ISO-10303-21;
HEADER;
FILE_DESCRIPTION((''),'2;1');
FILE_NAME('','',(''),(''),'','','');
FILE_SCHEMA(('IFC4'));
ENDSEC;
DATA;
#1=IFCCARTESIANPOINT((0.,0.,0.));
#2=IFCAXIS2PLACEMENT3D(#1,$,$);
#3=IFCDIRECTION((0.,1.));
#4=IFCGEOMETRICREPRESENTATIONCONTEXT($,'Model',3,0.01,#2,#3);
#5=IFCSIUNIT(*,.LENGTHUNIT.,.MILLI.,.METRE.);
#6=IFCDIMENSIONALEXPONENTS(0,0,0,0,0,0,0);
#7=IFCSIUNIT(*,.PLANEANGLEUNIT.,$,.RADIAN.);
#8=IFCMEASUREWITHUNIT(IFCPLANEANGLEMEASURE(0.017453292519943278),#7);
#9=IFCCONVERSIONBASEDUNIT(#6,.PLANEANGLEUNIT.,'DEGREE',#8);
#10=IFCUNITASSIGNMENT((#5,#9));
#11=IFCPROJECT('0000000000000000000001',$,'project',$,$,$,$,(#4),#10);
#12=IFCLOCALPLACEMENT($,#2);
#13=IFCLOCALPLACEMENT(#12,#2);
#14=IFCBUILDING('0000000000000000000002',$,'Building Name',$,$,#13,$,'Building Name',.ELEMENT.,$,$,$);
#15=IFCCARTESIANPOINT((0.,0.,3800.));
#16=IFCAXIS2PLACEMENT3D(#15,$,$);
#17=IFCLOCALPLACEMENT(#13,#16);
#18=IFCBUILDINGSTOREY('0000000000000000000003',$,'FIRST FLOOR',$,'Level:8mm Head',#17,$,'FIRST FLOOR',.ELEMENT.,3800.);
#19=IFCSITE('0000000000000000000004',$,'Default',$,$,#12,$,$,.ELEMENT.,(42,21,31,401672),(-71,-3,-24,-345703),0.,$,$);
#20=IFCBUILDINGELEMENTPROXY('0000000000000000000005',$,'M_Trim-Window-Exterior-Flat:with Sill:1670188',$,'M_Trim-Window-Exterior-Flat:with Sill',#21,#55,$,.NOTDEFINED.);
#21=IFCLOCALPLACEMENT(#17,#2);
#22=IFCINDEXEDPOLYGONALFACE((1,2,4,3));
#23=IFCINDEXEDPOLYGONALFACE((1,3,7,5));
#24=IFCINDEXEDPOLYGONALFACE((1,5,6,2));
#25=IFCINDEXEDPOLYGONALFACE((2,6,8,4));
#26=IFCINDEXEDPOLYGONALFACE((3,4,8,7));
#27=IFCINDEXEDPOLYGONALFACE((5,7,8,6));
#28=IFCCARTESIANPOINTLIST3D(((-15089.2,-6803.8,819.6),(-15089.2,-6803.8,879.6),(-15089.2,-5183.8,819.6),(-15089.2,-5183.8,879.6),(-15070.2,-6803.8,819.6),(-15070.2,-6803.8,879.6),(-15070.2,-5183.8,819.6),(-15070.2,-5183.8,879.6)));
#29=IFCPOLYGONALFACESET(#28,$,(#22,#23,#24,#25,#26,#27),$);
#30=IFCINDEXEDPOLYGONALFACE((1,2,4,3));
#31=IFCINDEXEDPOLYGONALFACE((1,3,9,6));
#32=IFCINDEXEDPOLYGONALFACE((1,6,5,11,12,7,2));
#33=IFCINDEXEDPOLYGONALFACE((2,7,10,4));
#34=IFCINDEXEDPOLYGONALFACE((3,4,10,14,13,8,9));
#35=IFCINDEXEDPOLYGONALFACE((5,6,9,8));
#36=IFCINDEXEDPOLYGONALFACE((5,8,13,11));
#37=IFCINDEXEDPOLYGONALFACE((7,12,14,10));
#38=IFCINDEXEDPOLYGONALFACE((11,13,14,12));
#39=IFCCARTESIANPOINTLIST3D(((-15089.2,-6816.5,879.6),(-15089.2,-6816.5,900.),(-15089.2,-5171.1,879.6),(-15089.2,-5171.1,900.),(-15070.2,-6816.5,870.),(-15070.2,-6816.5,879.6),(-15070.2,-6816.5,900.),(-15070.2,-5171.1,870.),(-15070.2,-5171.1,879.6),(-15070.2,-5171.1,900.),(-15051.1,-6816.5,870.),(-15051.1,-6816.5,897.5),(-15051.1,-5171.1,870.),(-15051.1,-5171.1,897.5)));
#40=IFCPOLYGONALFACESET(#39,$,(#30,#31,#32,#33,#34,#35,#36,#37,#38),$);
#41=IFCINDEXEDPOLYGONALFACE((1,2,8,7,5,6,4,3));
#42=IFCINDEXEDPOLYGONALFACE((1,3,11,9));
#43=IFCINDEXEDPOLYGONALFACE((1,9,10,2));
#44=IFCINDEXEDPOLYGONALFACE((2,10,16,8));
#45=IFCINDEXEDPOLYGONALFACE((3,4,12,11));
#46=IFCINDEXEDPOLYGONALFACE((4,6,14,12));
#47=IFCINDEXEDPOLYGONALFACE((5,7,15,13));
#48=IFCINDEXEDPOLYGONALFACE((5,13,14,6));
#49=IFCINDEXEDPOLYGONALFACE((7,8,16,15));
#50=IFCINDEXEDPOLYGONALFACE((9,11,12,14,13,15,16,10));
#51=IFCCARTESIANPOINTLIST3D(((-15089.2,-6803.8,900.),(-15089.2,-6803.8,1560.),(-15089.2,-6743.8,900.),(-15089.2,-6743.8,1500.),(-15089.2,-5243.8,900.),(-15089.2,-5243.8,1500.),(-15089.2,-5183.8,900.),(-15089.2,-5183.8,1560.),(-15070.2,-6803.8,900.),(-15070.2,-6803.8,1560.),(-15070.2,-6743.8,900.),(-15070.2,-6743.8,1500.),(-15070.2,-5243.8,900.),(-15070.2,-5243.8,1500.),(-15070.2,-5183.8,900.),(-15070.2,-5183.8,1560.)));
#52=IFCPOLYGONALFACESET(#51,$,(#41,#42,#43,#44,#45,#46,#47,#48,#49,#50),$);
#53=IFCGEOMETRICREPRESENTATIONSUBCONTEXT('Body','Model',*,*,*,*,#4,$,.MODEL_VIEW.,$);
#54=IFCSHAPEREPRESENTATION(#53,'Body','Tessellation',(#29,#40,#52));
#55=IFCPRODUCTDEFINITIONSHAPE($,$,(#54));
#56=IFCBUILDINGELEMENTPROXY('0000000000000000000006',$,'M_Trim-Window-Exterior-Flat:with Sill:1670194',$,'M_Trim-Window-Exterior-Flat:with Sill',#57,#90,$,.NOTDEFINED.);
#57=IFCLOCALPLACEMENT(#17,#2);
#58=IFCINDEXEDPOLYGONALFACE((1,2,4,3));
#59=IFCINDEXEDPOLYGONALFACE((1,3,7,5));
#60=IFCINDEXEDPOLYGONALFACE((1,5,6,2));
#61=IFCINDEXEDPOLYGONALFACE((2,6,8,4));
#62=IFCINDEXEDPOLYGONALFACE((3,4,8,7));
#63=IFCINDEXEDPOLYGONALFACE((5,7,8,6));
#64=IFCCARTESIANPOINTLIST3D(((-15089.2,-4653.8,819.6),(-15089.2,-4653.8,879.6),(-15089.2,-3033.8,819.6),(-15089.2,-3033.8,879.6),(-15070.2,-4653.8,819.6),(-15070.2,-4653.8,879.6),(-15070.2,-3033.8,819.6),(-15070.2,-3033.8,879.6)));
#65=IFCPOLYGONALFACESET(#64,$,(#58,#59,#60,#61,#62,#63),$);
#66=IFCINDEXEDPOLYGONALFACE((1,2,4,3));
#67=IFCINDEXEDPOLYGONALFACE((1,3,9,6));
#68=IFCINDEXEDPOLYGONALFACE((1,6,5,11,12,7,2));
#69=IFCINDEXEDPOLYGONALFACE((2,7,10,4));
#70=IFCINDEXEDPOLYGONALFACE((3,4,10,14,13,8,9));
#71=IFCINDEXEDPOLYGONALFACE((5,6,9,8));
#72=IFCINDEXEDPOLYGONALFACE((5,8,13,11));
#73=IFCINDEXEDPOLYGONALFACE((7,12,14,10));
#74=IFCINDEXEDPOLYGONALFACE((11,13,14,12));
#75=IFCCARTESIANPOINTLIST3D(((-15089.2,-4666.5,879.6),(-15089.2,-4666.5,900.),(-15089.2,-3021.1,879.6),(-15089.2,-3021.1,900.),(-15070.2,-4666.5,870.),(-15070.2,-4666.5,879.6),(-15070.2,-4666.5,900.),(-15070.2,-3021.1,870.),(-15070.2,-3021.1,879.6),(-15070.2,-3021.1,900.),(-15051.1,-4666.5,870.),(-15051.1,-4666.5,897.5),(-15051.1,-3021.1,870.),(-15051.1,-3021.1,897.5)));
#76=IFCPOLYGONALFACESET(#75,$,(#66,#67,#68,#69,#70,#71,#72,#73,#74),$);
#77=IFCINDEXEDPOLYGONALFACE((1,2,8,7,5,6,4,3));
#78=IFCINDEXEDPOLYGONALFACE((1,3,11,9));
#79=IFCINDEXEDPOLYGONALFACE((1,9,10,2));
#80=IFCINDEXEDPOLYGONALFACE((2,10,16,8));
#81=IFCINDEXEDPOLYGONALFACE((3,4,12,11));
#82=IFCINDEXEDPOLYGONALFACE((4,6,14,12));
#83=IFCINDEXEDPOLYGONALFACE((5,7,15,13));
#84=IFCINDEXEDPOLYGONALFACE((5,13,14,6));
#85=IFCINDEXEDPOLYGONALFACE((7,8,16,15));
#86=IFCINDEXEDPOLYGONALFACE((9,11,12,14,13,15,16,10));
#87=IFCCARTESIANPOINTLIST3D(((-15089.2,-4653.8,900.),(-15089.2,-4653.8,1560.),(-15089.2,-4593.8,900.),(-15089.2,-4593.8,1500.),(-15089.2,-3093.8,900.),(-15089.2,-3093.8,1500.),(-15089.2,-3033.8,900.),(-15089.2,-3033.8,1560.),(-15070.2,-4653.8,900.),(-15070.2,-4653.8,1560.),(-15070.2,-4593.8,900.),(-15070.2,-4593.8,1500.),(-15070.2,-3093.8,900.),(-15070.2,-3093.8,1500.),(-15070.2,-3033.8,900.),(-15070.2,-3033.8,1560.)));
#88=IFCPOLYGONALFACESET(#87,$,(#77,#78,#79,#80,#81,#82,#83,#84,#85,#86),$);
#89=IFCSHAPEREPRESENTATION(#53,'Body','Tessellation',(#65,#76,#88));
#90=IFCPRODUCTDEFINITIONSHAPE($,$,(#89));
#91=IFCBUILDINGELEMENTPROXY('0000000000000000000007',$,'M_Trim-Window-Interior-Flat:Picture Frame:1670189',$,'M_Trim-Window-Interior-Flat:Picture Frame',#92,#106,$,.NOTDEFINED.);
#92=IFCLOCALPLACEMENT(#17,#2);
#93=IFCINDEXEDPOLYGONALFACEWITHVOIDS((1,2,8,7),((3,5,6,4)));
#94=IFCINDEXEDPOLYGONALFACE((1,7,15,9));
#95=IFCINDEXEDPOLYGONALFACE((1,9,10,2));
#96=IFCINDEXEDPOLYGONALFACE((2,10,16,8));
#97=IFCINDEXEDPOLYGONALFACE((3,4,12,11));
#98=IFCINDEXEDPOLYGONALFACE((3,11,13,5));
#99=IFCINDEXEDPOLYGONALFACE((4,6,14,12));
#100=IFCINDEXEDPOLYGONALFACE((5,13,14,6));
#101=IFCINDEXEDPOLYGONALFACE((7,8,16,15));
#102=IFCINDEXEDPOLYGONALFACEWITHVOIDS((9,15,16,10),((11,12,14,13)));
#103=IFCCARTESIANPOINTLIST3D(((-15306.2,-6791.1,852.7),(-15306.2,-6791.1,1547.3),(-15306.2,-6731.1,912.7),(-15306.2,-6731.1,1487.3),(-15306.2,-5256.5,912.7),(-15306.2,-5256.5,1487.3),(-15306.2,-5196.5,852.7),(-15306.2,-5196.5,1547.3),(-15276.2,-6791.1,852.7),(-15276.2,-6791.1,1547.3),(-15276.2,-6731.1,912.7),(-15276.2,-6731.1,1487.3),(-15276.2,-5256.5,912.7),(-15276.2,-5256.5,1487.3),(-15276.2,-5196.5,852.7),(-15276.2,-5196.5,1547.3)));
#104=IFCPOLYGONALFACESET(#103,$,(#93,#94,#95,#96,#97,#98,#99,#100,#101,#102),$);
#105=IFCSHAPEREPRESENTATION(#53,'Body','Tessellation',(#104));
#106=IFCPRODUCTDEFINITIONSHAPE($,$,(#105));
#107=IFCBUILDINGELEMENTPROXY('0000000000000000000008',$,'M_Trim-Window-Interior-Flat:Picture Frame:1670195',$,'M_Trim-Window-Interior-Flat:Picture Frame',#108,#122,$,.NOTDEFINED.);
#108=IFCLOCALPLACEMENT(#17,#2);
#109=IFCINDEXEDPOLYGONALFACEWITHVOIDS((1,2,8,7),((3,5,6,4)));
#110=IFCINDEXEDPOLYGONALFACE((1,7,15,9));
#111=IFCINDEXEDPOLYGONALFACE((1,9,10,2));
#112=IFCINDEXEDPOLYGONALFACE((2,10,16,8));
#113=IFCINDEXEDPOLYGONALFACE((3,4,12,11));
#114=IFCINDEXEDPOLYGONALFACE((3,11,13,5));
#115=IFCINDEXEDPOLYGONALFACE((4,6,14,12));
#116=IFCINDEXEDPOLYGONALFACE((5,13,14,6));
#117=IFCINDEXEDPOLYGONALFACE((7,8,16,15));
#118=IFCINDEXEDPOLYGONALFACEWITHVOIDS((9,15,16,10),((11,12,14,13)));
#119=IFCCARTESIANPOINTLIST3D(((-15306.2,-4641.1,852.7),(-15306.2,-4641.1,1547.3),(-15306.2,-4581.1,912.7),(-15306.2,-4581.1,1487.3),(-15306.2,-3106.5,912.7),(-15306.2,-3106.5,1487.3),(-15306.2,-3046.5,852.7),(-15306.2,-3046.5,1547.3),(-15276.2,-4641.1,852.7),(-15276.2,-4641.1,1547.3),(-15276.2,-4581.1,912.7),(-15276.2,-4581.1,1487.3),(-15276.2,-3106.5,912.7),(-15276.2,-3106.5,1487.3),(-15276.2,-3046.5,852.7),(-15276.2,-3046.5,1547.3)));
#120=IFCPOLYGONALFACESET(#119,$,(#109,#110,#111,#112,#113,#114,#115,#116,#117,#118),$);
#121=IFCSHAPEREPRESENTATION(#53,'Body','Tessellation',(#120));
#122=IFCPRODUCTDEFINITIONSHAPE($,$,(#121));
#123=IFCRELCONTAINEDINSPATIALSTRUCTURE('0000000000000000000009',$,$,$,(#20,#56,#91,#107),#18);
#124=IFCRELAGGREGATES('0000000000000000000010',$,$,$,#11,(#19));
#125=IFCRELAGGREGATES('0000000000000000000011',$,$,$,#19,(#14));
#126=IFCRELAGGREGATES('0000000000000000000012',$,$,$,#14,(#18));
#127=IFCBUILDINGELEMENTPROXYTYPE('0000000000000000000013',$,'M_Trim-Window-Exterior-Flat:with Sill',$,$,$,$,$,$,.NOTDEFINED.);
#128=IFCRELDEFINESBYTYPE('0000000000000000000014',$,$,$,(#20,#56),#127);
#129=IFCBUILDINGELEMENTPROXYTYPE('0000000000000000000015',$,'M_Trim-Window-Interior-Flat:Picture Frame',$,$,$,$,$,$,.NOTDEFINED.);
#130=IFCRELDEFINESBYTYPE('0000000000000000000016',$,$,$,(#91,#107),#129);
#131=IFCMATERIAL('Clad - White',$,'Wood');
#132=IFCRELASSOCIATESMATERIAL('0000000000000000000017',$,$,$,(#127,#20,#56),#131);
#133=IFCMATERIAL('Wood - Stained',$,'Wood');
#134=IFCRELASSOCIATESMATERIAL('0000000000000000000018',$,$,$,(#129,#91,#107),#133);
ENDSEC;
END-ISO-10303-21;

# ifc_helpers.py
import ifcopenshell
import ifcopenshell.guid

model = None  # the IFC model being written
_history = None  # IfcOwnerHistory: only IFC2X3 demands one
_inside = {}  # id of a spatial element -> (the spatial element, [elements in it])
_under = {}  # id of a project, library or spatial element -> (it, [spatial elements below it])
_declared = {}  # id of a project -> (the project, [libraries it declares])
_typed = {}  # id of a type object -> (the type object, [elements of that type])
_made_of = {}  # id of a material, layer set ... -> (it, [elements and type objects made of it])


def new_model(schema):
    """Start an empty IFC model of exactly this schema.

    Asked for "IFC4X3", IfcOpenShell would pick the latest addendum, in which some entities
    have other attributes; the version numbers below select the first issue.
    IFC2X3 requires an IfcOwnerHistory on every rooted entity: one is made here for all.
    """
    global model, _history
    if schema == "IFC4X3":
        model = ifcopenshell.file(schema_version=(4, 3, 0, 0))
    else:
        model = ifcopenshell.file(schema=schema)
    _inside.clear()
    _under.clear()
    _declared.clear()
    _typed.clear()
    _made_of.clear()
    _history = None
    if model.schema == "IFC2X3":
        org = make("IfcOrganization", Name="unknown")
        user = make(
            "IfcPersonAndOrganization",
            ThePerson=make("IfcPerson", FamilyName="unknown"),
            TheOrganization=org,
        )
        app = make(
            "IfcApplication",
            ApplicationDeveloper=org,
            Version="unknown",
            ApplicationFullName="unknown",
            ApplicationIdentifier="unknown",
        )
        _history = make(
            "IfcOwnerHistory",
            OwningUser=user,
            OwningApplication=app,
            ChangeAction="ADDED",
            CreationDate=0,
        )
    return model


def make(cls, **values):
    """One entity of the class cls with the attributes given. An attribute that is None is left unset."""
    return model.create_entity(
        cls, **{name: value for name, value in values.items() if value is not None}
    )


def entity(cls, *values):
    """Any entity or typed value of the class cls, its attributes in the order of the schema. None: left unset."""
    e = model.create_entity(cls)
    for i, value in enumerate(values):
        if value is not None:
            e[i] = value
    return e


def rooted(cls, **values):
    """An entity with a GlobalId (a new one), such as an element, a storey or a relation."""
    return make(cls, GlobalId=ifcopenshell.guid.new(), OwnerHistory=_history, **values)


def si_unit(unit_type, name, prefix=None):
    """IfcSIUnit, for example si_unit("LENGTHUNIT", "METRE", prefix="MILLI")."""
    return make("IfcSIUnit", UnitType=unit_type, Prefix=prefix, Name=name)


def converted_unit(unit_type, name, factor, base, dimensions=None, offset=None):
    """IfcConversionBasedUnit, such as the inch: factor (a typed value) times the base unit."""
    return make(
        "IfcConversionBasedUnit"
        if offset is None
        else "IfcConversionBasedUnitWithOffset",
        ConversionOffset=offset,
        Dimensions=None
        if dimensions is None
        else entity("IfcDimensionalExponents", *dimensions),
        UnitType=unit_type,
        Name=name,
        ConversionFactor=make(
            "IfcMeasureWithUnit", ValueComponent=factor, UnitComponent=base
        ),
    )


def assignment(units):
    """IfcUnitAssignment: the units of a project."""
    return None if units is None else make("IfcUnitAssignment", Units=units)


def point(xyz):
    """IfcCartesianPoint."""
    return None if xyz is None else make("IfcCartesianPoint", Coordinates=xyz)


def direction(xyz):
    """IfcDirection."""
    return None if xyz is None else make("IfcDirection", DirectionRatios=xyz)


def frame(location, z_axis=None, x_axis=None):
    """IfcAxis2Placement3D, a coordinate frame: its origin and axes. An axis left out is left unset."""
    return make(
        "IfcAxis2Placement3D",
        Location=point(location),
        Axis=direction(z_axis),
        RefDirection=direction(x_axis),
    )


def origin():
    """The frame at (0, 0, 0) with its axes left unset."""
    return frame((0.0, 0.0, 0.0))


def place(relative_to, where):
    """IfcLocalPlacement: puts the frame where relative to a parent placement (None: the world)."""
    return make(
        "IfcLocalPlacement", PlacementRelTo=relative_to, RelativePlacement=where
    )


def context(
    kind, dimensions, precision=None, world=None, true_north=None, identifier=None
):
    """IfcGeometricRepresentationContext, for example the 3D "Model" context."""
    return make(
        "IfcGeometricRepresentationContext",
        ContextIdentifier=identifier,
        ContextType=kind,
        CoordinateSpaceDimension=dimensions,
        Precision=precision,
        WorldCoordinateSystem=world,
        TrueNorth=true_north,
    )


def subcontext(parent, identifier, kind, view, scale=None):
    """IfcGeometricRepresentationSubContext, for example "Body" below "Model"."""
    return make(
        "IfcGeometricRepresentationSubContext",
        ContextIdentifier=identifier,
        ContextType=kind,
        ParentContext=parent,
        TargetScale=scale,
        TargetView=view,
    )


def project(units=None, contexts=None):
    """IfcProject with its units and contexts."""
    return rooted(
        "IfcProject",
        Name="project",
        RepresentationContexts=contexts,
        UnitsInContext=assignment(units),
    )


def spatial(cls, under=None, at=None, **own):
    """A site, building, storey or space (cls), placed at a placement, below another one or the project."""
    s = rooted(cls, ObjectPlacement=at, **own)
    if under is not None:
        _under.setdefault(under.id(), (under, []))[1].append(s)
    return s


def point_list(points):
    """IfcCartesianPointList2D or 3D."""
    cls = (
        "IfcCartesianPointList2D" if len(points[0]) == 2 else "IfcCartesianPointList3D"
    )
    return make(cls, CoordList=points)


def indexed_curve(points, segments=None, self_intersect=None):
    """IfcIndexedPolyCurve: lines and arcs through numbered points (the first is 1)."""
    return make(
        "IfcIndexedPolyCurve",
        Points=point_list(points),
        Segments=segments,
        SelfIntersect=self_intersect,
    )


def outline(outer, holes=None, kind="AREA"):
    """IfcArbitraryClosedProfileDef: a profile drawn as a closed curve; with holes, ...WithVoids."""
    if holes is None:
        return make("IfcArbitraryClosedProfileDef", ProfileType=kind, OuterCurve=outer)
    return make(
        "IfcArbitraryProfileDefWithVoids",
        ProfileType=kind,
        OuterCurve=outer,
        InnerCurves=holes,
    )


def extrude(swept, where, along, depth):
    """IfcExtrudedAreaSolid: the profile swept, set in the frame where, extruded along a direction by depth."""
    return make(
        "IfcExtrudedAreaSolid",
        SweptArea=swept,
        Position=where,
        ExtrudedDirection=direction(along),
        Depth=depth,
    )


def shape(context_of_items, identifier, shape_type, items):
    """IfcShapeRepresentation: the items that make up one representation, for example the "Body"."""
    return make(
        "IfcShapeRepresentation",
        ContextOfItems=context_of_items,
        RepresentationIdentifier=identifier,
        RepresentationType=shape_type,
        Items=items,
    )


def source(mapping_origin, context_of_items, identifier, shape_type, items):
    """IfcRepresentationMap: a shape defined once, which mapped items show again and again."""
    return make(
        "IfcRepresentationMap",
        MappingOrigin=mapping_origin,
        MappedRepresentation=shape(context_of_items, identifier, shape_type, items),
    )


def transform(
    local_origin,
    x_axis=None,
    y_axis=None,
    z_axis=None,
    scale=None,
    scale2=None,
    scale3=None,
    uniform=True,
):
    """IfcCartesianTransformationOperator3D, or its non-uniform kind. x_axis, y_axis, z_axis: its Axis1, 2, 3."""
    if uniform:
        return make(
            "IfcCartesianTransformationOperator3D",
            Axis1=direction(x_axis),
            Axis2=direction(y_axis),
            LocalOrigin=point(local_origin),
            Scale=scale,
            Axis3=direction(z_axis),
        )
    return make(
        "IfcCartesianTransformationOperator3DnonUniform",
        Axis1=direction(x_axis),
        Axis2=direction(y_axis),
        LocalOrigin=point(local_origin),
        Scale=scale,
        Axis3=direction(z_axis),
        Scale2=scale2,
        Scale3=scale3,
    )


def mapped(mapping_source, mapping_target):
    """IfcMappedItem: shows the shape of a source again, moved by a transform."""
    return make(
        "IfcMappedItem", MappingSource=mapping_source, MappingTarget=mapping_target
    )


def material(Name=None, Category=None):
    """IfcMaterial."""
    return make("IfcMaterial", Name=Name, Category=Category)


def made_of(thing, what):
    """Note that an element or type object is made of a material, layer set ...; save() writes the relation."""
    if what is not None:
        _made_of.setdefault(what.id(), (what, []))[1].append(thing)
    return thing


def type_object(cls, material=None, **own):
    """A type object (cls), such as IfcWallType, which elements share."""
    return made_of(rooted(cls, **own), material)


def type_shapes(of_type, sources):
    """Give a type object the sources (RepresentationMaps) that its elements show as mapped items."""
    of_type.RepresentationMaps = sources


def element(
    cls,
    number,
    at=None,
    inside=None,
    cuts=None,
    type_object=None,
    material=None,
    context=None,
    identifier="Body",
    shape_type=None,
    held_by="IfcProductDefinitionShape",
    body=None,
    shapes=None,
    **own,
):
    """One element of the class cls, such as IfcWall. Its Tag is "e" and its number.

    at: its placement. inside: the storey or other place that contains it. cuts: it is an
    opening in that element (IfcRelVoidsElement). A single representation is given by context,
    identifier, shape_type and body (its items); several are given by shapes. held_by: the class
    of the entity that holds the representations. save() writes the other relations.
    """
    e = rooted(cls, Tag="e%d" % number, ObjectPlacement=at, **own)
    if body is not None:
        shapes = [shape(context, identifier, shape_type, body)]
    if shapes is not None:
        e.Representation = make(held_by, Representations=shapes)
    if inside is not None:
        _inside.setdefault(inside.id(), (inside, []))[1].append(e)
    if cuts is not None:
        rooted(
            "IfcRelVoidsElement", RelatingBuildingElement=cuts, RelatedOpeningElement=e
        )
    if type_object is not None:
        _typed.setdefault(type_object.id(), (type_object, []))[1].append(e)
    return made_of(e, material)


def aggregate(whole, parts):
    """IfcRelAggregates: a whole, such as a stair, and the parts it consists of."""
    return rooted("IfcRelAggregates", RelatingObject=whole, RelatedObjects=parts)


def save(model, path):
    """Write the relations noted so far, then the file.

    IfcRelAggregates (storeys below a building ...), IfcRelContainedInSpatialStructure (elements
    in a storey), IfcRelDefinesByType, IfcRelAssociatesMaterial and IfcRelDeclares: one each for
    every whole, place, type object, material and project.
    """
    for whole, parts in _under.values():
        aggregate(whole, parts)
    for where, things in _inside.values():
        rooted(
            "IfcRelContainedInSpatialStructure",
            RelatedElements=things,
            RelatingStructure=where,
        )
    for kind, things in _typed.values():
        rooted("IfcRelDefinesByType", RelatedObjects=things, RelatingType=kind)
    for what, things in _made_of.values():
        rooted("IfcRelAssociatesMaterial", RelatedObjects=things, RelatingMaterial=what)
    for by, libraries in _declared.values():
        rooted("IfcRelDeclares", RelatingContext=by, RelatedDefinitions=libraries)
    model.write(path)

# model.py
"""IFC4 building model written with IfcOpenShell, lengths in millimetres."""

from ifc_helpers import new_model, entity, si_unit, converted_unit, direction, frame, origin, place, context, subcontext, project, spatial, indexed_curve, outline, extrude, source, transform, mapped, material, type_object, type_shapes, element, save


model = new_model("IFC4")

# Units and contexts
model_context = context("Model", 3, precision=0.01, world=origin(), true_north=direction((0.0, 1.0)))
body_context = subcontext(model_context, "Body", "Model", "MODEL_VIEW")
ifc_project = project(units=[si_unit("LENGTHUNIT", "METRE", prefix="MILLI"), converted_unit("PLANEANGLEUNIT", "DEGREE", entity("IfcPlaneAngleMeasure", 0.017453292519943278), si_unit("PLANEANGLEUNIT", "RADIAN"), dimensions=[0, 0, 0, 0, 0, 0, 0])], contexts=[model_context])

# Site, building, storey
site_placement = place(None, origin())
site = spatial("IfcSite", under=ifc_project, at=site_placement, Name="Default", CompositionType="ELEMENT", RefLatitude=(42, 21, 31, 401672), RefLongitude=(-71, -3, -24, -345703), RefElevation=0.0)
building_placement = place(site_placement, origin())
building = spatial("IfcBuilding", under=site, at=building_placement, Name="Building Name", LongName="Building Name", CompositionType="ELEMENT")
storey_placement = place(building_placement, frame((0.0, 0.0, 3800.0)))
storey = spatial("IfcBuildingStorey", under=building, at=storey_placement, Name="FIRST FLOOR", ObjectType="Level:8mm Head", LongName="FIRST FLOOR", CompositionType="ELEMENT", Elevation=3800.0)

# Shared definitions
ifc_material_1 = material(Name="Wood - Stained", Category="Wood")

# Building element proxies
ifc_material_2 = material(Name="Clad - White", Category="Wood")
building_element_proxy_type_1 = type_object("IfcBuildingElementProxyType", Name="M_Trim-Window-Exterior-Flat:with Sill", PredefinedType="NOTDEFINED", material=ifc_material_2)
shared_shape_1 = source(origin(), body_context, "Body", "SweptSolid", [
    extrude(outline(indexed_curve([(-810.0, -30.0), (810.0, -30.0), (810.0, 30.0), (-810.0, 30.0), (-810.0, -30.0)], self_intersect=False)), frame((0.0, -650.4, 0.0), z_axis=(0.0, 0.0, 1.0), x_axis=(-1.0, 0.0, 0.0)), (0.0, 0.0, 1.0), 19.0),
    extrude(outline(indexed_curve([(-19.0, -15.2), (0.0, -15.2), (0.0, -5.7), (19.0, -5.7), (19.0, 14.8), (0.0, 14.8), (-19.0, 12.3), (-19.0, -15.2)], self_intersect=False)), frame((-822.7, -614.8, 19.0), z_axis=(1.0, 0.0, 0.0), x_axis=(0.0, 0.0, -1.0)), (0.0, 0.0, 1.0), 1645.4),
    extrude(outline(indexed_curve([(-345.0, -810.0), (315.0, -810.0), (315.0, -750.0), (-285.0, -750.0), (-285.0, 750.0), (315.0, 750.0), (315.0, 810.0), (-345.0, 810.0), (-345.0, -810.0)], self_intersect=False)), frame((0.0, -285.0, 0.0), z_axis=(0.0, 0.0, 1.0), x_axis=(0.0, -1.0, 0.0)), (0.0, 0.0, 1.0), 19.0),
])
type_shapes(building_element_proxy_type_1, [shared_shape_1])
for number, where, z_axis, x_axis, name in (
    (1, (-15089.2, -5993.8, 1500.0), (1.0, 0.0, 0.0), (0.0, 1.0, 0.0), "M_Trim-Window-Exterior-Flat:with Sill:1670188"),
    (2, (-15089.2, -3843.8, 1500.0), (1.0, 0.0, 0.0), (0.0, 1.0, 0.0), "M_Trim-Window-Exterior-Flat:with Sill:1670194"),
):
    element("IfcBuildingElementProxy", number, at=place(storey_placement, frame(where, z_axis=z_axis, x_axis=x_axis)), inside=storey, type_object=building_element_proxy_type_1, material=ifc_material_2, Name=name, ObjectType="M_Trim-Window-Exterior-Flat:with Sill", PredefinedType="NOTDEFINED", context=body_context, shape_type="MappedRepresentation", body=[
        mapped(shared_shape_1, transform((0.0, 0.0, 0.0), scale=1.0)),
    ])
building_element_proxy_type_2 = type_object("IfcBuildingElementProxyType", Name="M_Trim-Window-Interior-Flat:Picture Frame", PredefinedType="NOTDEFINED", material=ifc_material_1)
shared_shape_2 = source(origin(), body_context, "Body", "SweptSolid", [
    extrude(outline(indexed_curve([(-797.3, -347.3), (797.3, -347.3), (797.3, 347.3), (-797.3, 347.3), (-797.3, -347.3)], self_intersect=False), holes=[indexed_curve([(-737.3, -287.3), (-737.3, 287.3), (737.3, 287.3), (737.3, -287.3), (-737.3, -287.3)], self_intersect=False)]), frame((0.0, -300.0, 0.0), z_axis=(0.0, 0.0, 1.0), x_axis=(-1.0, 0.0, 0.0)), (0.0, 0.0, 1.0), 30.0),
])
type_shapes(building_element_proxy_type_2, [shared_shape_2])
for number, where, z_axis, x_axis, name in (
    (3, (-15276.2, -5993.8, 1500.0), (-1.0, 0.0, 0.0), (0.0, -1.0, 0.0), "M_Trim-Window-Interior-Flat:Picture Frame:1670189"),
    (4, (-15276.2, -3843.8, 1500.0), (-1.0, 0.0, 0.0), (0.0, -1.0, 0.0), "M_Trim-Window-Interior-Flat:Picture Frame:1670195"),
):
    element("IfcBuildingElementProxy", number, at=place(storey_placement, frame(where, z_axis=z_axis, x_axis=x_axis)), inside=storey, type_object=building_element_proxy_type_2, material=ifc_material_1, Name=name, ObjectType="M_Trim-Window-Interior-Flat:Picture Frame", PredefinedType="NOTDEFINED", context=body_context, shape_type="MappedRepresentation", body=[
        mapped(shared_shape_2, transform((0.0, 0.0, 0.0), scale=1.0)),
    ])

save(model, "model.ifc")
